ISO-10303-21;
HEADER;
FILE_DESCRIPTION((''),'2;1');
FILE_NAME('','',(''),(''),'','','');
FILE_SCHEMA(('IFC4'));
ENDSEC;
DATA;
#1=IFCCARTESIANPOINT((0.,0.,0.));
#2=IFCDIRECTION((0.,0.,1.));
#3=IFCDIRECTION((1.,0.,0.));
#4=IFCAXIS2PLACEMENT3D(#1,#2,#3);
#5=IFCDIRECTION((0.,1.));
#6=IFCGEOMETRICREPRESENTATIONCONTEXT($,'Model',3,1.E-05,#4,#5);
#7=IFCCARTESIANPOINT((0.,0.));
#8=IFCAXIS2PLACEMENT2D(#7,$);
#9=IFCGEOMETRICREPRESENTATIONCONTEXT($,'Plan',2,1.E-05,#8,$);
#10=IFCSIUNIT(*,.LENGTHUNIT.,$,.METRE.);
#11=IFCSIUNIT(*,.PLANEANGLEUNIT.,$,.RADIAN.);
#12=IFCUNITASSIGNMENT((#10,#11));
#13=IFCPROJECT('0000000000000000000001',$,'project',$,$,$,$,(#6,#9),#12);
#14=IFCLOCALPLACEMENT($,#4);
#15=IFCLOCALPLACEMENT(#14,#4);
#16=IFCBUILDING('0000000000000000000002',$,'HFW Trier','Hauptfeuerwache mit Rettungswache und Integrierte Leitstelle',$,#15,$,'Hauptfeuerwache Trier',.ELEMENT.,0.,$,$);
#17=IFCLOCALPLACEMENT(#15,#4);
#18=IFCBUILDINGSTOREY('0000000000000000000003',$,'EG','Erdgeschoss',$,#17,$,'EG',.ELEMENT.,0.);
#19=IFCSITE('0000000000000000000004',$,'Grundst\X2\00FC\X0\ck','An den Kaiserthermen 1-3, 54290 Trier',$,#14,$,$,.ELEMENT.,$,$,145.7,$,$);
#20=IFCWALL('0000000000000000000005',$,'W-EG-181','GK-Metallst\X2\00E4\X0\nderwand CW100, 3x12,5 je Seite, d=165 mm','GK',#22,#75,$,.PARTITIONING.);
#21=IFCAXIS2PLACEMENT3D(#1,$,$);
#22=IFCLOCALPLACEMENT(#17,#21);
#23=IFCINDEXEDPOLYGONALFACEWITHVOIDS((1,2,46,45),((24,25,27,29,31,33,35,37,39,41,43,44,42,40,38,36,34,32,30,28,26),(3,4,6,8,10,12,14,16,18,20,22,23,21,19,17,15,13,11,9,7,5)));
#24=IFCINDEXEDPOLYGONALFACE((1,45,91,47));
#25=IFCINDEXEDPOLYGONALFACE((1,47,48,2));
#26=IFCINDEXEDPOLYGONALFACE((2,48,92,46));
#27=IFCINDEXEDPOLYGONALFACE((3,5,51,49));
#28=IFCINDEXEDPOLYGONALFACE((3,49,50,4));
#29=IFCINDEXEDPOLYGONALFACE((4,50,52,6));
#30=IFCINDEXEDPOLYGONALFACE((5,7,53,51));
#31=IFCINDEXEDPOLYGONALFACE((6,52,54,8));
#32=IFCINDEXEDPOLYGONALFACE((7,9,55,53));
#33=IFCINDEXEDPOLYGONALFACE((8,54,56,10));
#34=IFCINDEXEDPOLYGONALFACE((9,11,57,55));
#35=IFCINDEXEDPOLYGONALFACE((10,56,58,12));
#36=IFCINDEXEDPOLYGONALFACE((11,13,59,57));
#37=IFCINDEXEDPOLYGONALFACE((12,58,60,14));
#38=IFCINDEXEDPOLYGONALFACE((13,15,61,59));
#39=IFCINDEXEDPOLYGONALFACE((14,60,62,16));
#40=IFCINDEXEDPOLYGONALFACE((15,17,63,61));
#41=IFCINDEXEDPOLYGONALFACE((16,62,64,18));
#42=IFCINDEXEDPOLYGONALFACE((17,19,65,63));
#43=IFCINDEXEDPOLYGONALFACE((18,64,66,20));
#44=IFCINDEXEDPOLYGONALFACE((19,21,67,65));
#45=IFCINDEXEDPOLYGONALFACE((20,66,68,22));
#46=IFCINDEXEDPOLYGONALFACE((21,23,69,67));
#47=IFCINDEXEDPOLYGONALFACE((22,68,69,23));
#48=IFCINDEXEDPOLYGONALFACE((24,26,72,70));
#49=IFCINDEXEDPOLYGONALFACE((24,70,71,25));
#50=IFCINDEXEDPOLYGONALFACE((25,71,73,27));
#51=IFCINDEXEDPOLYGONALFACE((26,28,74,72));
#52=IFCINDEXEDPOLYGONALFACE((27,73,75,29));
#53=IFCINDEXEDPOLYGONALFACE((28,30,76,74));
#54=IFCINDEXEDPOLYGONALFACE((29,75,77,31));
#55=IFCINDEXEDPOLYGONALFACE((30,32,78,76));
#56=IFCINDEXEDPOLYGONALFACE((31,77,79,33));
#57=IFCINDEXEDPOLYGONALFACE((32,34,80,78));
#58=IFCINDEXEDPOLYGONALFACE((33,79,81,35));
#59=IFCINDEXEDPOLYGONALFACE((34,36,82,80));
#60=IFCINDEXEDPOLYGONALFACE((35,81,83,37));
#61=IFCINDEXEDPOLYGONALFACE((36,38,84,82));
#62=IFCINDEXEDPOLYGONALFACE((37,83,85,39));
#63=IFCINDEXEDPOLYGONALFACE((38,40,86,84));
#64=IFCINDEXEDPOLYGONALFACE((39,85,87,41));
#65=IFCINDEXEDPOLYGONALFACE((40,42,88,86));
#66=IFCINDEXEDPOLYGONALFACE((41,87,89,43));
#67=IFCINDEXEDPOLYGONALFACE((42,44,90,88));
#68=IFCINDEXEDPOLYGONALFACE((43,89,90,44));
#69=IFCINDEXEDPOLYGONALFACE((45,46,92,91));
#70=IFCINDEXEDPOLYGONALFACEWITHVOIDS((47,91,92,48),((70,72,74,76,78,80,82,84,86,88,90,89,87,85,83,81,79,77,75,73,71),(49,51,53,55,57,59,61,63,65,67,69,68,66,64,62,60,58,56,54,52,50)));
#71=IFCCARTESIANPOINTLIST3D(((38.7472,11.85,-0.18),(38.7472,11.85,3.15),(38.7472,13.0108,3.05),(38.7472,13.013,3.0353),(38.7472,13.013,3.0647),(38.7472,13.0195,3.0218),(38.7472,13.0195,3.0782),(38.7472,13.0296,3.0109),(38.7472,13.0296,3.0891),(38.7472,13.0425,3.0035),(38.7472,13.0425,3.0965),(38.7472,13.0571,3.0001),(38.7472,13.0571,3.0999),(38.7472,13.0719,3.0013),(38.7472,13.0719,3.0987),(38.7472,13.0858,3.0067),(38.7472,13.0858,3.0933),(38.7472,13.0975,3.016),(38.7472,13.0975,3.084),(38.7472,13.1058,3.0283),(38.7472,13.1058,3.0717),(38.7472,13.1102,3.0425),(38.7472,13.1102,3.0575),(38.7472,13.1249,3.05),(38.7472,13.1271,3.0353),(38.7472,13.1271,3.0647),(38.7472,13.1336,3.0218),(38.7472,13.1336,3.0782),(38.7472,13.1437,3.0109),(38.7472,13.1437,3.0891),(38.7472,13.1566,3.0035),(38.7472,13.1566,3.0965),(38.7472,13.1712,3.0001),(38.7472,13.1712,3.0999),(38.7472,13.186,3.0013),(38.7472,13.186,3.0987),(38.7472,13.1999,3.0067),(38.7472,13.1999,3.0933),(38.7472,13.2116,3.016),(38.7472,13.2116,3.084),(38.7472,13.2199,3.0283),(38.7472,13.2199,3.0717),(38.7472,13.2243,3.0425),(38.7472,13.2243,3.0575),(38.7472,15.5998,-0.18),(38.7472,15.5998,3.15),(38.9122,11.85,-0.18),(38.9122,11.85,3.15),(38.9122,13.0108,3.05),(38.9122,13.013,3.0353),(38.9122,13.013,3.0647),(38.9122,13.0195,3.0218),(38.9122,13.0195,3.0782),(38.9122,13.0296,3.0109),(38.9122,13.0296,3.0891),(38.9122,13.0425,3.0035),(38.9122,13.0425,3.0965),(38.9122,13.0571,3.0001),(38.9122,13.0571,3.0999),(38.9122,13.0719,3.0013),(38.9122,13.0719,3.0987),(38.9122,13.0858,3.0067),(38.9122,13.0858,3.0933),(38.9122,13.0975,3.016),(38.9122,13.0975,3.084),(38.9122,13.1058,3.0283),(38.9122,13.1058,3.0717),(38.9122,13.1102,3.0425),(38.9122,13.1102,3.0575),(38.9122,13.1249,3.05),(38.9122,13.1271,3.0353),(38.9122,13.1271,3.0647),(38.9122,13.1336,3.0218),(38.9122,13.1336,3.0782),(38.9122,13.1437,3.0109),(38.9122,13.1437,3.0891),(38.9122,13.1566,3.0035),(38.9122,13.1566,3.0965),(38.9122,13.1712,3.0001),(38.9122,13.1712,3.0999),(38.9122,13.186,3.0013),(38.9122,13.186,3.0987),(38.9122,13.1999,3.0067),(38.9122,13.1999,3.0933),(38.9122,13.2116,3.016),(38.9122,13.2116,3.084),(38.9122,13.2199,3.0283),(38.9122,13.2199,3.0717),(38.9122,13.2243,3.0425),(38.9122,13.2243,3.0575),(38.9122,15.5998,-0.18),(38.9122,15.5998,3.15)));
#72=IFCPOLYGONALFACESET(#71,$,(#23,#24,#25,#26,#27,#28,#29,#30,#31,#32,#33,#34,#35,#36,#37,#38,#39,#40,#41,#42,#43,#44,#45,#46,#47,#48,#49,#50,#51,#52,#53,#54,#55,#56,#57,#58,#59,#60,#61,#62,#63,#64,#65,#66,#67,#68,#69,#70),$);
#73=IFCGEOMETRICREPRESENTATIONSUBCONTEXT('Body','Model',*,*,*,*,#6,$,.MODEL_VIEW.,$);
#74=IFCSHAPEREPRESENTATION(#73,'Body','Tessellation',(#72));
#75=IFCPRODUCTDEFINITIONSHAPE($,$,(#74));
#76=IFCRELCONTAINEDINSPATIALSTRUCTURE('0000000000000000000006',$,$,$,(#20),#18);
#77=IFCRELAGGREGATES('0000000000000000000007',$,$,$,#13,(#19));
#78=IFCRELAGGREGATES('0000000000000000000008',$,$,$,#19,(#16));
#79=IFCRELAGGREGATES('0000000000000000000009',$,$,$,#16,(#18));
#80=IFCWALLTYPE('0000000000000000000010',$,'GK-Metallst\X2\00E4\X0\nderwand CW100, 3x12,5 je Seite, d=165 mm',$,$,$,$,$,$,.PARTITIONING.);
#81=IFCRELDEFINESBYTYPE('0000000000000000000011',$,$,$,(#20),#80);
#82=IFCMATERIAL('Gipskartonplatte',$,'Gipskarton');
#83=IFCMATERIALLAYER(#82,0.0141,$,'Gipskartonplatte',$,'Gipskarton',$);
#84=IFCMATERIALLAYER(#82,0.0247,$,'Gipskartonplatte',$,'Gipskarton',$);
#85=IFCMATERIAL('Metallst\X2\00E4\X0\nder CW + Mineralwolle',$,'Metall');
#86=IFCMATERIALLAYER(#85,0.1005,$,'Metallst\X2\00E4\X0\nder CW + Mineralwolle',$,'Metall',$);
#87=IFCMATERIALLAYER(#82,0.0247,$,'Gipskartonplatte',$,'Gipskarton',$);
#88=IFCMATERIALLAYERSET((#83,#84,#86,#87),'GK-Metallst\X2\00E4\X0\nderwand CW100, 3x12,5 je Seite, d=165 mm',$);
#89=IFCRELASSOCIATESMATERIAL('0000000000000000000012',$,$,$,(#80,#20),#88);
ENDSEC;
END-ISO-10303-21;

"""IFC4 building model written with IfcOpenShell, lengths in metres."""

from ifc_helpers import new_model, si_unit, direction, frame, frame_2d, origin_with_axes, origin_2d, place, context, subcontext, project, spatial, rectangle, circle, extrude, material, layer, layer_set, layer_usage, type_object, element, save


model = new_model("IFC4")

# Units and contexts
model_context = context("Model", 3, precision=1e-05, world=origin_with_axes(), true_north=direction((0.0, 1.0)))
plan_context = context("Plan", 2, precision=1e-05, world=origin_2d())
body_context = subcontext(model_context, "Body", "Model", "MODEL_VIEW")
ifc_project = project(units=[si_unit("LENGTHUNIT", "METRE"), si_unit("PLANEANGLEUNIT", "RADIAN")], contexts=[model_context, plan_context])

# Site, building, storey
site_placement = place(None, origin_with_axes())
site = spatial("IfcSite", under=ifc_project, at=site_placement, Name="Grundstück", Description="An den Kaiserthermen 1-3, 54290 Trier", CompositionType="ELEMENT", RefElevation=145.7)
building_placement = place(site_placement, origin_with_axes())
building = spatial("IfcBuilding", under=site, at=building_placement, Name="HFW Trier", Description="Hauptfeuerwache mit Rettungswache und Integrierte Leitstelle", LongName="Hauptfeuerwache Trier", CompositionType="ELEMENT", ElevationOfRefHeight=0.0)
storey_placement = place(building_placement, origin_with_axes())
storey = spatial("IfcBuildingStorey", under=building, at=storey_placement, Name="EG", Description="Erdgeschoss", LongName="EG", CompositionType="ELEMENT", Elevation=0.0)

# Shared definitions
ifc_material_1 = material(Name="Gipskartonplatte", Category="Gipskarton")
ifc_material_2 = material(Name="Metallständer CW + Mineralwolle", Category="Metall")

# Wall, openings
ifc_layer_1 = layer(ifc_material_1, 0.0141, Name="Gipskartonplatte", Category="Gipskarton")
ifc_layer_2 = layer(ifc_material_1, 0.0247, Name="Gipskartonplatte", Category="Gipskarton")
ifc_layer_3 = layer(ifc_material_2, 0.1005, Name="Metallständer CW + Mineralwolle", Category="Metall")
ifc_layer_4 = layer(ifc_material_1, 0.0247, Name="Gipskartonplatte", Category="Gipskarton")
ifc_layer_set_1 = layer_set([ifc_layer_1, ifc_layer_2, ifc_layer_3, ifc_layer_4], Name="GK-Metallständerwand CW100, 3x12,5 je Seite, d=165 mm")
ifc_layer_usage_1 = layer_usage(ifc_layer_set_1, "AXIS2", "POSITIVE", -0.0825)
wall_type_1 = type_object("IfcWallType", Name="GK-Metallständerwand CW100, 3x12,5 je Seite, d=165 mm", PredefinedType="PARTITIONING", material=ifc_layer_set_1)
wall_1_placement = place(storey_placement, frame((38.8297, 15.5998, -0.18), z_axis=(0.0, 0.0, 1.0), x_axis=(0.0, -1.0, 0.0)))
wall_1 = element("IfcWall", 1, at=wall_1_placement, inside=storey, type_object=wall_type_1, material=ifc_layer_usage_1, Name="W-EG-181", Description="GK-Metallständerwand CW100, 3x12,5 je Seite, d=165 mm", ObjectType="GK", PredefinedType="PARTITIONING", context=body_context, shape_type="SweptSolid", body=[
    extrude(rectangle(XDim=3.7498, YDim=0.165, at=frame_2d((1.8749, 0.0))), origin_with_axes(), (0.0, 0.0, 1.0), 3.33),
])
opening_1_placement = place(wall_1_placement, origin_with_axes())
element("IfcOpeningElement", 2, at=opening_1_placement, cuts=wall_1, ObjectType="Wanddurchbruch", PredefinedType="OPENING", context=body_context, shape_type="SweptSolid", body=[
    extrude(circle(Radius=0.05, at=origin_2d()), frame((2.4249, -0.1325, 3.23), z_axis=(0.0, 1.0, 0.0), x_axis=(1.0, 0.0, 0.0)), (0.0, 0.0, 1.0), 0.265),
])
opening_2_placement = place(wall_1_placement, origin_with_axes())
element("IfcOpeningElement", 3, at=opening_2_placement, cuts=wall_1, ObjectType="Wanddurchbruch", PredefinedType="OPENING", context=body_context, shape_type="SweptSolid", body=[
    extrude(circle(Radius=0.05, at=origin_2d()), frame((2.539, -0.1325, 3.23), z_axis=(0.0, 1.0, 0.0), x_axis=(1.0, 0.0, 0.0)), (0.0, 0.0, 1.0), 0.265),
])

save(model, "model.ifc")
